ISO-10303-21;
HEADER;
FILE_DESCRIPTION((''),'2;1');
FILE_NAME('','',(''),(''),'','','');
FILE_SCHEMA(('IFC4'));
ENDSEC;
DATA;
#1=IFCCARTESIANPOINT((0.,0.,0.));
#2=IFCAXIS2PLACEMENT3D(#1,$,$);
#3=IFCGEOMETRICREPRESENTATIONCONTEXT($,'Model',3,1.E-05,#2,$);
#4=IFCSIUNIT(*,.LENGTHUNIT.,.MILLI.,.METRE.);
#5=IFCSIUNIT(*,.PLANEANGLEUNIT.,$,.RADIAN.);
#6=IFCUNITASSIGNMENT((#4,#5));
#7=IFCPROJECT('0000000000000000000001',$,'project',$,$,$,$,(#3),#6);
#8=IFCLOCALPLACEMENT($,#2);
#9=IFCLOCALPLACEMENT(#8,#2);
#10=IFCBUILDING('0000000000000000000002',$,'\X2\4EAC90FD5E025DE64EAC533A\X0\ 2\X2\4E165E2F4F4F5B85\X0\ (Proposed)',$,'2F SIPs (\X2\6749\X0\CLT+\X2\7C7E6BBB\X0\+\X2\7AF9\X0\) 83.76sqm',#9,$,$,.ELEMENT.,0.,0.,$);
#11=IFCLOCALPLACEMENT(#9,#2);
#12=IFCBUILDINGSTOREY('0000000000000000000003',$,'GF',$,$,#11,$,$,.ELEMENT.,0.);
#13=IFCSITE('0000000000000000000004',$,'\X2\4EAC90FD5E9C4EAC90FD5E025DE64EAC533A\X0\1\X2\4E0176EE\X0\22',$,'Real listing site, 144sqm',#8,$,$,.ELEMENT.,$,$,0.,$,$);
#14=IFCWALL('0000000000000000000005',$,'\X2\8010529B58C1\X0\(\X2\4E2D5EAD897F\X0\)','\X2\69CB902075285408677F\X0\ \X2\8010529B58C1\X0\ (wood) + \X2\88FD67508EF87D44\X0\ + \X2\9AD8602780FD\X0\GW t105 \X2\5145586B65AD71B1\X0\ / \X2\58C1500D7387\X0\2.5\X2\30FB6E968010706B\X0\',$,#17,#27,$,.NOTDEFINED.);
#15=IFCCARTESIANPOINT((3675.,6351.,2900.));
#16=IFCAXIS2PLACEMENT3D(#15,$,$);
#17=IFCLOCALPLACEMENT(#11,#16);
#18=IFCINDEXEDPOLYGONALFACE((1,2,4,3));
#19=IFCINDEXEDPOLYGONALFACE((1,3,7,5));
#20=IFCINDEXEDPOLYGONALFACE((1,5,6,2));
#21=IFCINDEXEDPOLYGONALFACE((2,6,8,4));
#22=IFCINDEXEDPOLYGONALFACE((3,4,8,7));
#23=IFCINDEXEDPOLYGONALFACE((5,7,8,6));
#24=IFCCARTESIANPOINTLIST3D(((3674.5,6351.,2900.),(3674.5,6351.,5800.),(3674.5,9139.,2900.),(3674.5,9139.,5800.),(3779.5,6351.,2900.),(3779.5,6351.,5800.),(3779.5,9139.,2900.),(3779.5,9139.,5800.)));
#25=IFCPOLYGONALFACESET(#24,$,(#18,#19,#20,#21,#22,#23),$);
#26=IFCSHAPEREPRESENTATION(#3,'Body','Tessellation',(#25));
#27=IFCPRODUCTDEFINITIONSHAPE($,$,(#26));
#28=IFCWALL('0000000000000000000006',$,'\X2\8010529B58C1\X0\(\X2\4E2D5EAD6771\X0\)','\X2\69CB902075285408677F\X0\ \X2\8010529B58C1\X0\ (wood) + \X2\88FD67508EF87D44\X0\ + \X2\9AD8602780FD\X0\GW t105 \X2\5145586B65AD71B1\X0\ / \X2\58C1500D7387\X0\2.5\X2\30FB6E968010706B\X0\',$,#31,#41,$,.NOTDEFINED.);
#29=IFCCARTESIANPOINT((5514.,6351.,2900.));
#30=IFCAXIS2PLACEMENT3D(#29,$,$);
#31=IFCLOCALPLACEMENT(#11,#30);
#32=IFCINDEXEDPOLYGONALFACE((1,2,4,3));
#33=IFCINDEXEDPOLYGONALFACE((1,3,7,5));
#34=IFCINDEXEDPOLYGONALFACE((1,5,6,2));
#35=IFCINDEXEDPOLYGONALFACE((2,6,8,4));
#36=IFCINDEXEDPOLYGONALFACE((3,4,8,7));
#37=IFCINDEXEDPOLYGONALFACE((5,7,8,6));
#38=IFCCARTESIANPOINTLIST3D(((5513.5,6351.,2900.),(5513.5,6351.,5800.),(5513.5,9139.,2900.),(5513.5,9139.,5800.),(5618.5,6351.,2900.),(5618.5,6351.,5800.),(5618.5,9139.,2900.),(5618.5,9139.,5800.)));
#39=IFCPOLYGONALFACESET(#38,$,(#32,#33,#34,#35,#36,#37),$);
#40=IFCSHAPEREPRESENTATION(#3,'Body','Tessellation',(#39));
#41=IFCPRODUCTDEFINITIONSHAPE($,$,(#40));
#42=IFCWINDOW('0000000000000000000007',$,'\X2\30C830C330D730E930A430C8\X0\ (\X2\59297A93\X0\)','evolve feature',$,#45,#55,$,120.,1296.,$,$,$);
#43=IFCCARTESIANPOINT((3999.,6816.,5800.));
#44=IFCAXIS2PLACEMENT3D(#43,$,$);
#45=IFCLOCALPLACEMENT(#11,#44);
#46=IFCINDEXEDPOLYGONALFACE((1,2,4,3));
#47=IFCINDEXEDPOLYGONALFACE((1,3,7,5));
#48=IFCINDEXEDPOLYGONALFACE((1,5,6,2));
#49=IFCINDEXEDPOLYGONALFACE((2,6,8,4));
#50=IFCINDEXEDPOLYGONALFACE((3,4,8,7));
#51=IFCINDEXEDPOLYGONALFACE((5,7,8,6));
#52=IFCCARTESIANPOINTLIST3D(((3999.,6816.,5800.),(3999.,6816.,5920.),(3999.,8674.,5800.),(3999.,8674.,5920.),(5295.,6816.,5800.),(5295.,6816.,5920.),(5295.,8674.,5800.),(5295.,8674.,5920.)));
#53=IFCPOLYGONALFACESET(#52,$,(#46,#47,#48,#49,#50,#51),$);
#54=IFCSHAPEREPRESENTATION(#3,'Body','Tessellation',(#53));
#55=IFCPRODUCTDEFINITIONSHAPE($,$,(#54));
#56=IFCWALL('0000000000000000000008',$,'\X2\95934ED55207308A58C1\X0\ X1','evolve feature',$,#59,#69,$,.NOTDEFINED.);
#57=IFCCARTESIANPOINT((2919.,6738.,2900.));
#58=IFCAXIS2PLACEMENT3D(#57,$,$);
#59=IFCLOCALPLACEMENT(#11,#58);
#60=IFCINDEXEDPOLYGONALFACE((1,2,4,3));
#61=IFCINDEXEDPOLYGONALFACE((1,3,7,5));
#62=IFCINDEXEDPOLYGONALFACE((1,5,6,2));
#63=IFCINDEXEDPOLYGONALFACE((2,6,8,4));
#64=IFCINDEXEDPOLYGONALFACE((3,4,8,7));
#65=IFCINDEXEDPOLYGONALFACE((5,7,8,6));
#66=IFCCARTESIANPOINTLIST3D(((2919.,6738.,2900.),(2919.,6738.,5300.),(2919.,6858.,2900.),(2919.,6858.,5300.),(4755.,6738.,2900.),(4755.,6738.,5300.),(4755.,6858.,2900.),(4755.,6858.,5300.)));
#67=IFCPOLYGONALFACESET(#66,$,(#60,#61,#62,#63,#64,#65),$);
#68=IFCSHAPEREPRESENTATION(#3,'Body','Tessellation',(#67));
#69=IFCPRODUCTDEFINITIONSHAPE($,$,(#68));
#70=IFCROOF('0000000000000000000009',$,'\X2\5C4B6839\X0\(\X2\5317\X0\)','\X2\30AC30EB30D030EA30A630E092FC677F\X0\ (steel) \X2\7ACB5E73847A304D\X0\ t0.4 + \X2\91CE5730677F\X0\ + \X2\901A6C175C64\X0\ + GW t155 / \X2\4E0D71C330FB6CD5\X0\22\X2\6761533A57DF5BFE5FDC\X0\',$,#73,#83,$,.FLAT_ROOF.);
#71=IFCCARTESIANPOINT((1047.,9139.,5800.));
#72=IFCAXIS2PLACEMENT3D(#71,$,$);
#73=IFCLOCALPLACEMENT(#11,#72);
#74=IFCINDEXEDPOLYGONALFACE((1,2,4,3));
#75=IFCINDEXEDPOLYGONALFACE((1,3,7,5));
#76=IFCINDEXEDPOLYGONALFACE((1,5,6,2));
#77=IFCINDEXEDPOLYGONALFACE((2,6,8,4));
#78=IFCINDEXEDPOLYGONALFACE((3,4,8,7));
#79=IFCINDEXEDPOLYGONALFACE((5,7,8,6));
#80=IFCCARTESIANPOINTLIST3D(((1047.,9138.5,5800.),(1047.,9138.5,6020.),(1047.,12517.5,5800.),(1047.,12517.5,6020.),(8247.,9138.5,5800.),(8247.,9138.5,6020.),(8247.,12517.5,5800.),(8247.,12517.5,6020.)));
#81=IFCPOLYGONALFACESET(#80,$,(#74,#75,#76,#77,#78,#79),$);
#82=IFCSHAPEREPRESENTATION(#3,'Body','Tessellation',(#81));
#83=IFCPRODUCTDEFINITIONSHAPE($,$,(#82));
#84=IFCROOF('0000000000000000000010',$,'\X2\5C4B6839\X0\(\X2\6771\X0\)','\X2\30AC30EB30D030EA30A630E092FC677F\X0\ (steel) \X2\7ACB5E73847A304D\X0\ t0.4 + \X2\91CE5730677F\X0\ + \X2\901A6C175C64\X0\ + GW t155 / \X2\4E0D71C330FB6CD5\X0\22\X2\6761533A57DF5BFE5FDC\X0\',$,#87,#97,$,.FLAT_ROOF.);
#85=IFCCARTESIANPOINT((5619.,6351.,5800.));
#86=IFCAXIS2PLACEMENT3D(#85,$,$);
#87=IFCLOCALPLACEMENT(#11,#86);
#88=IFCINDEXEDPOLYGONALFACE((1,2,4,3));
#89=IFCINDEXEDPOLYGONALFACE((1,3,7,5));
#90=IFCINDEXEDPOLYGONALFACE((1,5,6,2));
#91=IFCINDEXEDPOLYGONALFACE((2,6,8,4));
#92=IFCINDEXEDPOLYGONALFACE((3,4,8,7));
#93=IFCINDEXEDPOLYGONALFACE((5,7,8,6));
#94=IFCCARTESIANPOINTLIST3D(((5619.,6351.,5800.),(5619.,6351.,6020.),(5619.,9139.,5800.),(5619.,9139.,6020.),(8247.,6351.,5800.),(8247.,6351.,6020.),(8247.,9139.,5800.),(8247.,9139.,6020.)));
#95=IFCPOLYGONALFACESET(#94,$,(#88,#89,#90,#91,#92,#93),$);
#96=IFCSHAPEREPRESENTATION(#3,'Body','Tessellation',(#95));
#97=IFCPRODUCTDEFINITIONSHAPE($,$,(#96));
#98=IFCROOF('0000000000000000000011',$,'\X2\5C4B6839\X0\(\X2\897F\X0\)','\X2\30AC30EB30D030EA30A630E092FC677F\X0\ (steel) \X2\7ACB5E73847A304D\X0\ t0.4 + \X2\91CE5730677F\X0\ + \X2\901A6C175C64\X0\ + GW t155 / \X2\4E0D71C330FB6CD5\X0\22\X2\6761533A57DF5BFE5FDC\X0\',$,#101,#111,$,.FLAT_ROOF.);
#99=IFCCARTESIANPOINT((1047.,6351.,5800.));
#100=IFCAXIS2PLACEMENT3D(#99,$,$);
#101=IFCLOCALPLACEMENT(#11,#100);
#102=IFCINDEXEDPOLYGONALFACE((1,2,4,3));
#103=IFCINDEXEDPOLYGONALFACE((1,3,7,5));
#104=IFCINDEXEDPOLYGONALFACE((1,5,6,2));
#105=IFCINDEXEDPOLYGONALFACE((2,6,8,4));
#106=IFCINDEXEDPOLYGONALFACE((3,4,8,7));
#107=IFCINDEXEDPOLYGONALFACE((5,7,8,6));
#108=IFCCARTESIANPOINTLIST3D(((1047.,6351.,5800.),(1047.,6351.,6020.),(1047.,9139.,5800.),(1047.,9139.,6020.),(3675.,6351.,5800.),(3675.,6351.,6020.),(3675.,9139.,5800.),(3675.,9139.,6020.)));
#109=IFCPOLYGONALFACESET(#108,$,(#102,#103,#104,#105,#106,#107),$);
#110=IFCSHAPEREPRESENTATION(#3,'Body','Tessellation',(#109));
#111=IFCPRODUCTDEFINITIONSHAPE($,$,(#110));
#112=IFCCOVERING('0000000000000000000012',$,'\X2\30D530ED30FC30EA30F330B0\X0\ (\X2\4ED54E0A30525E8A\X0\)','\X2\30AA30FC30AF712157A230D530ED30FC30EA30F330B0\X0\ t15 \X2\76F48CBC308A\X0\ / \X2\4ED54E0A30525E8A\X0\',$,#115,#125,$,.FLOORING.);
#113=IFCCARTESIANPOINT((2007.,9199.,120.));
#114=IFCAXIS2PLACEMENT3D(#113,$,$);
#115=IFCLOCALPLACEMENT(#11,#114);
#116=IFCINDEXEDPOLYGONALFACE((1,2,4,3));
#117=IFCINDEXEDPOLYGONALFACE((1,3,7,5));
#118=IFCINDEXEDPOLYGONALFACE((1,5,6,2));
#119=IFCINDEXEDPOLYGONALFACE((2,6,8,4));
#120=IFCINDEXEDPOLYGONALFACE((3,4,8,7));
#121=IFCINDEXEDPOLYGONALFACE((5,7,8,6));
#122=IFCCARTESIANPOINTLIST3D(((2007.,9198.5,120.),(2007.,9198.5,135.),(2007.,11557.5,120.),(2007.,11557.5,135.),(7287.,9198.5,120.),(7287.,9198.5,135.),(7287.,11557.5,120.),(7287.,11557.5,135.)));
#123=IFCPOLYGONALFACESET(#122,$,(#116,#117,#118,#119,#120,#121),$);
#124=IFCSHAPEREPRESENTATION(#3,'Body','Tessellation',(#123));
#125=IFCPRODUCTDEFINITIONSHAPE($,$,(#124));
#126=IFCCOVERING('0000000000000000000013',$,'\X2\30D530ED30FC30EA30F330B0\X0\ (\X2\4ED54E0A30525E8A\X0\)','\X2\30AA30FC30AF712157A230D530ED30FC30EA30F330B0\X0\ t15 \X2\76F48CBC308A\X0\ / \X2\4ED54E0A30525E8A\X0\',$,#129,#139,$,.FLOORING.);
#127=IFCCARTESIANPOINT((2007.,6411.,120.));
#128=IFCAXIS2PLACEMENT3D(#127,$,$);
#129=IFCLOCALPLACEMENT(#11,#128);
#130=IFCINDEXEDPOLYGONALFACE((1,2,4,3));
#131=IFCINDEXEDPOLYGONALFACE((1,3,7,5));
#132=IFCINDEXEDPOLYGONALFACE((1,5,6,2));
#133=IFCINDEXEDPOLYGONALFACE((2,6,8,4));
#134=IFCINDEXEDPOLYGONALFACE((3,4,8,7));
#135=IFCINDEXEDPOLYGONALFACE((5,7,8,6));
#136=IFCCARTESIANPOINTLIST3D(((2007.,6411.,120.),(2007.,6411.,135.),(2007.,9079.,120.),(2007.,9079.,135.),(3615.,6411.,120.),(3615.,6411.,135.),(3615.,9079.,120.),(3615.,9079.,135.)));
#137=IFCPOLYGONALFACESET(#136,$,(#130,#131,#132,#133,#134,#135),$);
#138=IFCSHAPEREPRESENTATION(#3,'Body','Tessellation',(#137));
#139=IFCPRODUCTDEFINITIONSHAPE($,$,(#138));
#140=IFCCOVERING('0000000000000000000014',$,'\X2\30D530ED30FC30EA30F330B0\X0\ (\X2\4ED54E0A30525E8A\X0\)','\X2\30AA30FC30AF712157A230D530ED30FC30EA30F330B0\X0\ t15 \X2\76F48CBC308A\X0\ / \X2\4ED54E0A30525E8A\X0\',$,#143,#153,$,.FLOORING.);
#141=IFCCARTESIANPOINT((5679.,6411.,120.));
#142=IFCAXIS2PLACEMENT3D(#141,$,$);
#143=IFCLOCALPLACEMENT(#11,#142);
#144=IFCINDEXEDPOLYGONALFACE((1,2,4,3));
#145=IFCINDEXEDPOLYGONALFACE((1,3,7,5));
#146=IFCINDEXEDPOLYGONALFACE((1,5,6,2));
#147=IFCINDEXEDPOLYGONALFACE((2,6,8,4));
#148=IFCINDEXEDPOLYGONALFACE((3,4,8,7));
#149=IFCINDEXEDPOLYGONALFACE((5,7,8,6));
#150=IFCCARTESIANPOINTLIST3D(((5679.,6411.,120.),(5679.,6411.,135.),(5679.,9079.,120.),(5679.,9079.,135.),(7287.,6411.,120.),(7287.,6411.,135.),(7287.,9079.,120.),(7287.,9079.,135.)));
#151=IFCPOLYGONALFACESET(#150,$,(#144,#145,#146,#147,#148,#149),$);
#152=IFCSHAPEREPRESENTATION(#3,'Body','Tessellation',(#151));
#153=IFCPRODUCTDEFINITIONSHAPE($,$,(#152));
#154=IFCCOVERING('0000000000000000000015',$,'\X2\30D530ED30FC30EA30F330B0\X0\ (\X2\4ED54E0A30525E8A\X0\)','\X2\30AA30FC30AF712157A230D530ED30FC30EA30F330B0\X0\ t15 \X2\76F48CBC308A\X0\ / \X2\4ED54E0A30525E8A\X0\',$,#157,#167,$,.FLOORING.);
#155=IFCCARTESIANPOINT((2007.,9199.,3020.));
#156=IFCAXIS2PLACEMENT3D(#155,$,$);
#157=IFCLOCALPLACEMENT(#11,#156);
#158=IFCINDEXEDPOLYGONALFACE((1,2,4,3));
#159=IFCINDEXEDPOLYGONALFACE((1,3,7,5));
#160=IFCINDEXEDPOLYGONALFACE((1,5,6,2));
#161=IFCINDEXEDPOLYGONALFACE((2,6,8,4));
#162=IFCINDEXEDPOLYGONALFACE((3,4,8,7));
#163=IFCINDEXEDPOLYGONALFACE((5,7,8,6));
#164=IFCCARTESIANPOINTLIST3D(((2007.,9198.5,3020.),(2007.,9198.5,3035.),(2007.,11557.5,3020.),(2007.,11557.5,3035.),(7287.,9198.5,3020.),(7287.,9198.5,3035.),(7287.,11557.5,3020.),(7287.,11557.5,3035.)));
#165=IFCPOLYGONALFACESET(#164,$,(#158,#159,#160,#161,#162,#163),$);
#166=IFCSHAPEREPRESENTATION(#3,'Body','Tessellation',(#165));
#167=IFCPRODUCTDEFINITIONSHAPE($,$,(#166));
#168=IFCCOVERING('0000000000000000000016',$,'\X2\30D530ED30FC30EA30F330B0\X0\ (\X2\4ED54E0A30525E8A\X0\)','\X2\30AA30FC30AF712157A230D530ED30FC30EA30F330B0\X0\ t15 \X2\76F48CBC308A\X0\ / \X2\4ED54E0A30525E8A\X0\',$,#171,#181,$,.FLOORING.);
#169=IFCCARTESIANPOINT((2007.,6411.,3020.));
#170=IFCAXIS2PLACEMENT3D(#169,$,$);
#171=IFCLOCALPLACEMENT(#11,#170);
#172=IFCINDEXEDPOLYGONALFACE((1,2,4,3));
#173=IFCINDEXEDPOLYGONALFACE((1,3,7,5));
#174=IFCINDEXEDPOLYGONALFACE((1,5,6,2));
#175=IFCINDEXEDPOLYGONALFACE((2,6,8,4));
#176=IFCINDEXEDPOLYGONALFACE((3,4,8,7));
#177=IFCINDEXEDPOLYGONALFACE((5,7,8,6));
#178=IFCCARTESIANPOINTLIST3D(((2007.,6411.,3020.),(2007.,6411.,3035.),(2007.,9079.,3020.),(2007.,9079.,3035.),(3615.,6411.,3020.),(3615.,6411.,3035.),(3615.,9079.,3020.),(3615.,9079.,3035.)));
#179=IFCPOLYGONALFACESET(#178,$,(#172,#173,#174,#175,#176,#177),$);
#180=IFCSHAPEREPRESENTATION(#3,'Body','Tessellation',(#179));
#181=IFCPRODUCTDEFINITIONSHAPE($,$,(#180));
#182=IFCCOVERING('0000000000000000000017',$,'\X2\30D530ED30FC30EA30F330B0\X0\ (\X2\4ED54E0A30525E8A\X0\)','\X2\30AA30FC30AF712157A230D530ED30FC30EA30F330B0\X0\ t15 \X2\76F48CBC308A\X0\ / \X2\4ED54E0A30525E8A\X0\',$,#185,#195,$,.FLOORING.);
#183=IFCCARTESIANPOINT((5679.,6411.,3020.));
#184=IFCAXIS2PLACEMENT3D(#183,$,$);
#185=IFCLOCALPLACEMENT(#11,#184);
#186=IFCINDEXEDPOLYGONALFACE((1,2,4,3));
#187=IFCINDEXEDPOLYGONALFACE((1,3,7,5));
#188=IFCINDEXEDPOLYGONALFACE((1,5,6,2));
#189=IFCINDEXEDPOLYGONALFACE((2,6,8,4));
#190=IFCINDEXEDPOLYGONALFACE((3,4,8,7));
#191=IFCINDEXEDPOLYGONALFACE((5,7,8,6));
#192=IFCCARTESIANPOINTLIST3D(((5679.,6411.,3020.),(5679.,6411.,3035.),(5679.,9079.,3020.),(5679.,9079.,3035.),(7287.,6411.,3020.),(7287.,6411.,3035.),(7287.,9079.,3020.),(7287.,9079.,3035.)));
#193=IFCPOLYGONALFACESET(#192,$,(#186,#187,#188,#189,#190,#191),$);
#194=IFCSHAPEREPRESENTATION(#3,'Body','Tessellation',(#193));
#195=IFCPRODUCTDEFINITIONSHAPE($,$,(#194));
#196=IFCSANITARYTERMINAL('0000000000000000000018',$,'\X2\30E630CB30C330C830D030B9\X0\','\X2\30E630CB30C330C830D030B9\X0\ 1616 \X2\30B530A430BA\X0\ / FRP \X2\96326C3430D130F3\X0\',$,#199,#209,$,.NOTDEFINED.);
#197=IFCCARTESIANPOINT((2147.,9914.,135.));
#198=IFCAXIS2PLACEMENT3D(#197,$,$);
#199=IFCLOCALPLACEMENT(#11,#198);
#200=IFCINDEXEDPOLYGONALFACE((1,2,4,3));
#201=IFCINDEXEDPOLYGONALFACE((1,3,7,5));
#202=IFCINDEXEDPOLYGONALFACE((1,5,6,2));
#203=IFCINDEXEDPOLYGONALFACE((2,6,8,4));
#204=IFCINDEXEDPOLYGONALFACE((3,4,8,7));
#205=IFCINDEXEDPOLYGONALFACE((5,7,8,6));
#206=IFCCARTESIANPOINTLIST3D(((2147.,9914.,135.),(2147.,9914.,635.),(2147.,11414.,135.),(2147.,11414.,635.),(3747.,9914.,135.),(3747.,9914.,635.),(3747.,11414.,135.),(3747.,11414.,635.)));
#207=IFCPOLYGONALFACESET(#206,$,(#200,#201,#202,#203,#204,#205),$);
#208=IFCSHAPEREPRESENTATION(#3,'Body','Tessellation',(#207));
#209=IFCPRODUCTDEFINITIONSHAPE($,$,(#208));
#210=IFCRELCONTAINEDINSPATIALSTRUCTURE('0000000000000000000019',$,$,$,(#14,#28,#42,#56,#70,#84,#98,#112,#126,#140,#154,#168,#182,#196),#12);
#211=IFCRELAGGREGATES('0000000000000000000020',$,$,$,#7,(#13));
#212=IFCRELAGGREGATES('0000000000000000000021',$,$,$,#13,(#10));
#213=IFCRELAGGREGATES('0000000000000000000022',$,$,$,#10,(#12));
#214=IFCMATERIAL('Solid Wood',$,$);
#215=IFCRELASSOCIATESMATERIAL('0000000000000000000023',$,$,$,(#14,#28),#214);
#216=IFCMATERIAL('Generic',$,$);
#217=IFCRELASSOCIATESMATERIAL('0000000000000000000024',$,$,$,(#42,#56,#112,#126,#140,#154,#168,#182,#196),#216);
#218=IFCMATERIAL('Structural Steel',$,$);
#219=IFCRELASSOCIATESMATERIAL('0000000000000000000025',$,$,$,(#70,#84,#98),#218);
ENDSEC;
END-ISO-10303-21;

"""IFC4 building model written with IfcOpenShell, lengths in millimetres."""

from ifc_helpers import new_model, si_unit, frame, frame_2d, origin, place, context, project, spatial, rectangle, extrude, material, element, save


model = new_model("IFC4")

# Units and contexts
model_context = context("Model", 3, precision=1e-05, world=origin())
ifc_project = project(units=[si_unit("LENGTHUNIT", "METRE", prefix="MILLI"), si_unit("PLANEANGLEUNIT", "RADIAN")], contexts=[model_context])

# Site, building, storey
site_placement = place(None, origin())
site = spatial("IfcSite", under=ifc_project, at=site_placement, Name="京都府京都市左京区1丁目22", ObjectType="Real listing site, 144sqm", CompositionType="ELEMENT", RefElevation=0.0)
building_placement = place(site_placement, origin())
building = spatial("IfcBuilding", under=site, at=building_placement, Name="京都市左京区 2世帯住宅 (Proposed)", ObjectType="2F SIPs (杉CLT+籾殻+竹) 83.76sqm", CompositionType="ELEMENT", ElevationOfRefHeight=0.0, ElevationOfTerrain=0.0)
storey_placement = place(building_placement, origin())
storey = spatial("IfcBuildingStorey", under=building, at=storey_placement, Name="GF", CompositionType="ELEMENT", Elevation=0.0)

# Shared definitions
ifc_material_1 = material(Name="Solid Wood")

# Walls
wall_1_placement = place(storey_placement, frame((3675.0, 6351.0, 2900.0)))
element("IfcWall", 1, at=wall_1_placement, inside=storey, material=ifc_material_1, Name="耐力壁(中庭西)", Description="構造用合板 耐力壁 (wood) + 製材軸組 + 高性能GW t105 充填断熱 / 壁倍率2.5・準耐火", PredefinedType="NOTDEFINED", context=model_context, shape_type="SweptSolid", body=[
    extrude(rectangle(XDim=105.0, YDim=2788.0, at=frame_2d((52.0, 1394.0))), frame((3675.0, 6351.0, 2900.0)), (0.0, 0.0, 1.0), 2900.0),
])
wall_2_placement = place(storey_placement, frame((5514.0, 6351.0, 2900.0)))
element("IfcWall", 2, at=wall_2_placement, inside=storey, material=ifc_material_1, Name="耐力壁(中庭東)", Description="構造用合板 耐力壁 (wood) + 製材軸組 + 高性能GW t105 充填断熱 / 壁倍率2.5・準耐火", PredefinedType="NOTDEFINED", context=model_context, shape_type="SweptSolid", body=[
    extrude(rectangle(XDim=105.0, YDim=2788.0, at=frame_2d((52.0, 1394.0))), frame((5514.0, 6351.0, 2900.0)), (0.0, 0.0, 1.0), 2900.0),
])

# Window
ifc_material_2 = material(Name="Generic")
window_1_placement = place(storey_placement, frame((3999.0, 6816.0, 5800.0)))
element("IfcWindow", 3, at=window_1_placement, inside=storey, material=ifc_material_2, Name="トップライト (天窓)", Description="evolve feature", OverallHeight=120.0, OverallWidth=1296.0, context=model_context, shape_type="SweptSolid", body=[
    extrude(rectangle(XDim=1296.0, YDim=1858.0, at=frame_2d((648.0, 929.0))), frame((3999.0, 6816.0, 5800.0)), (0.0, 0.0, 1.0), 120.0),
])

# Wall
wall_3_placement = place(storey_placement, frame((2919.0, 6738.0, 2900.0)))
element("IfcWall", 4, at=wall_3_placement, inside=storey, material=ifc_material_2, Name="間仕切り壁 X1", Description="evolve feature", PredefinedType="NOTDEFINED", context=model_context, shape_type="SweptSolid", body=[
    extrude(rectangle(XDim=1836.0, YDim=120.0, at=frame_2d((918.0, 60.0))), frame((2919.0, 6738.0, 2900.0)), (0.0, 0.0, 1.0), 2400.0),
])

# Roofs
ifc_material_3 = material(Name="Structural Steel")
roof_1_placement = place(storey_placement, frame((1047.0, 9139.0, 5800.0)))
element("IfcRoof", 5, at=roof_1_placement, inside=storey, material=ifc_material_3, Name="屋根(北)", Description="ガルバリウム鋼板 (steel) 立平葺き t0.4 + 野地板 + 通気層 + GW t155 / 不燃・法22条区域対応", PredefinedType="FLAT_ROOF", context=model_context, shape_type="SweptSolid", body=[
    extrude(rectangle(XDim=7200.0, YDim=3379.0, at=frame_2d((3600.0, 1689.0))), frame((1047.0, 9139.0, 5800.0)), (0.0, 0.0, 1.0), 220.0),
])
roof_2_placement = place(storey_placement, frame((5619.0, 6351.0, 5800.0)))
element("IfcRoof", 6, at=roof_2_placement, inside=storey, material=ifc_material_3, Name="屋根(東)", Description="ガルバリウム鋼板 (steel) 立平葺き t0.4 + 野地板 + 通気層 + GW t155 / 不燃・法22条区域対応", PredefinedType="FLAT_ROOF", context=model_context, shape_type="SweptSolid", body=[
    extrude(rectangle(XDim=2628.0, YDim=2788.0, at=frame_2d((1314.0, 1394.0))), frame((5619.0, 6351.0, 5800.0)), (0.0, 0.0, 1.0), 220.0),
])
roof_3_placement = place(storey_placement, frame((1047.0, 6351.0, 5800.0)))
element("IfcRoof", 7, at=roof_3_placement, inside=storey, material=ifc_material_3, Name="屋根(西)", Description="ガルバリウム鋼板 (steel) 立平葺き t0.4 + 野地板 + 通気層 + GW t155 / 不燃・法22条区域対応", PredefinedType="FLAT_ROOF", context=model_context, shape_type="SweptSolid", body=[
    extrude(rectangle(XDim=2628.0, YDim=2788.0, at=frame_2d((1314.0, 1394.0))), frame((1047.0, 6351.0, 5800.0)), (0.0, 0.0, 1.0), 220.0),
])

# Coverings
covering_1_placement = place(storey_placement, frame((2007.0, 9199.0, 120.0)))
element("IfcCovering", 8, at=covering_1_placement, inside=storey, material=ifc_material_2, Name="フローリング (仕上げ床)", Description="オーク無垢フローリング t15 直貼り / 仕上げ床", PredefinedType="FLOORING", context=model_context, shape_type="SweptSolid", body=[
    extrude(rectangle(XDim=5280.0, YDim=2359.0, at=frame_2d((2640.0, 1179.0))), frame((2007.0, 9199.0, 120.0)), (0.0, 0.0, 1.0), 15.0),
])
covering_2_placement = place(storey_placement, frame((2007.0, 6411.0, 120.0)))
element("IfcCovering", 9, at=covering_2_placement, inside=storey, material=ifc_material_2, Name="フローリング (仕上げ床)", Description="オーク無垢フローリング t15 直貼り / 仕上げ床", PredefinedType="FLOORING", context=model_context, shape_type="SweptSolid", body=[
    extrude(rectangle(XDim=1608.0, YDim=2668.0, at=frame_2d((804.0, 1334.0))), frame((2007.0, 6411.0, 120.0)), (0.0, 0.0, 1.0), 15.0),
])
covering_3_placement = place(storey_placement, frame((5679.0, 6411.0, 120.0)))
element("IfcCovering", 10, at=covering_3_placement, inside=storey, material=ifc_material_2, Name="フローリング (仕上げ床)", Description="オーク無垢フローリング t15 直貼り / 仕上げ床", PredefinedType="FLOORING", context=model_context, shape_type="SweptSolid", body=[
    extrude(rectangle(XDim=1608.0, YDim=2668.0, at=frame_2d((804.0, 1334.0))), frame((5679.0, 6411.0, 120.0)), (0.0, 0.0, 1.0), 15.0),
])
covering_4_placement = place(storey_placement, frame((2007.0, 9199.0, 3020.0)))
element("IfcCovering", 11, at=covering_4_placement, inside=storey, material=ifc_material_2, Name="フローリング (仕上げ床)", Description="オーク無垢フローリング t15 直貼り / 仕上げ床", PredefinedType="FLOORING", context=model_context, shape_type="SweptSolid", body=[
    extrude(rectangle(XDim=5280.0, YDim=2359.0, at=frame_2d((2640.0, 1179.0))), frame((2007.0, 9199.0, 3020.0)), (0.0, 0.0, 1.0), 15.0),
])
covering_5_placement = place(storey_placement, frame((2007.0, 6411.0, 3020.0)))
element("IfcCovering", 12, at=covering_5_placement, inside=storey, material=ifc_material_2, Name="フローリング (仕上げ床)", Description="オーク無垢フローリング t15 直貼り / 仕上げ床", PredefinedType="FLOORING", context=model_context, shape_type="SweptSolid", body=[
    extrude(rectangle(XDim=1608.0, YDim=2668.0, at=frame_2d((804.0, 1334.0))), frame((2007.0, 6411.0, 3020.0)), (0.0, 0.0, 1.0), 15.0),
])
covering_6_placement = place(storey_placement, frame((5679.0, 6411.0, 3020.0)))
element("IfcCovering", 13, at=covering_6_placement, inside=storey, material=ifc_material_2, Name="フローリング (仕上げ床)", Description="オーク無垢フローリング t15 直貼り / 仕上げ床", PredefinedType="FLOORING", context=model_context, shape_type="SweptSolid", body=[
    extrude(rectangle(XDim=1608.0, YDim=2668.0, at=frame_2d((804.0, 1334.0))), frame((5679.0, 6411.0, 3020.0)), (0.0, 0.0, 1.0), 15.0),
])

# Sanitary terminal
sanitary_terminal_1_placement = place(storey_placement, frame((2147.0, 9914.0, 135.0)))
element("IfcSanitaryTerminal", 14, at=sanitary_terminal_1_placement, inside=storey, material=ifc_material_2, Name="ユニットバス", Description="ユニットバス 1616 サイズ / FRP 防水パン", PredefinedType="NOTDEFINED", context=model_context, shape_type="SweptSolid", body=[
    extrude(rectangle(XDim=1600.0, YDim=1500.0, at=frame_2d((800.0, 750.0))), frame((2147.0, 9914.0, 135.0)), (0.0, 0.0, 1.0), 500.0),
])

save(model, "model.ifc")
